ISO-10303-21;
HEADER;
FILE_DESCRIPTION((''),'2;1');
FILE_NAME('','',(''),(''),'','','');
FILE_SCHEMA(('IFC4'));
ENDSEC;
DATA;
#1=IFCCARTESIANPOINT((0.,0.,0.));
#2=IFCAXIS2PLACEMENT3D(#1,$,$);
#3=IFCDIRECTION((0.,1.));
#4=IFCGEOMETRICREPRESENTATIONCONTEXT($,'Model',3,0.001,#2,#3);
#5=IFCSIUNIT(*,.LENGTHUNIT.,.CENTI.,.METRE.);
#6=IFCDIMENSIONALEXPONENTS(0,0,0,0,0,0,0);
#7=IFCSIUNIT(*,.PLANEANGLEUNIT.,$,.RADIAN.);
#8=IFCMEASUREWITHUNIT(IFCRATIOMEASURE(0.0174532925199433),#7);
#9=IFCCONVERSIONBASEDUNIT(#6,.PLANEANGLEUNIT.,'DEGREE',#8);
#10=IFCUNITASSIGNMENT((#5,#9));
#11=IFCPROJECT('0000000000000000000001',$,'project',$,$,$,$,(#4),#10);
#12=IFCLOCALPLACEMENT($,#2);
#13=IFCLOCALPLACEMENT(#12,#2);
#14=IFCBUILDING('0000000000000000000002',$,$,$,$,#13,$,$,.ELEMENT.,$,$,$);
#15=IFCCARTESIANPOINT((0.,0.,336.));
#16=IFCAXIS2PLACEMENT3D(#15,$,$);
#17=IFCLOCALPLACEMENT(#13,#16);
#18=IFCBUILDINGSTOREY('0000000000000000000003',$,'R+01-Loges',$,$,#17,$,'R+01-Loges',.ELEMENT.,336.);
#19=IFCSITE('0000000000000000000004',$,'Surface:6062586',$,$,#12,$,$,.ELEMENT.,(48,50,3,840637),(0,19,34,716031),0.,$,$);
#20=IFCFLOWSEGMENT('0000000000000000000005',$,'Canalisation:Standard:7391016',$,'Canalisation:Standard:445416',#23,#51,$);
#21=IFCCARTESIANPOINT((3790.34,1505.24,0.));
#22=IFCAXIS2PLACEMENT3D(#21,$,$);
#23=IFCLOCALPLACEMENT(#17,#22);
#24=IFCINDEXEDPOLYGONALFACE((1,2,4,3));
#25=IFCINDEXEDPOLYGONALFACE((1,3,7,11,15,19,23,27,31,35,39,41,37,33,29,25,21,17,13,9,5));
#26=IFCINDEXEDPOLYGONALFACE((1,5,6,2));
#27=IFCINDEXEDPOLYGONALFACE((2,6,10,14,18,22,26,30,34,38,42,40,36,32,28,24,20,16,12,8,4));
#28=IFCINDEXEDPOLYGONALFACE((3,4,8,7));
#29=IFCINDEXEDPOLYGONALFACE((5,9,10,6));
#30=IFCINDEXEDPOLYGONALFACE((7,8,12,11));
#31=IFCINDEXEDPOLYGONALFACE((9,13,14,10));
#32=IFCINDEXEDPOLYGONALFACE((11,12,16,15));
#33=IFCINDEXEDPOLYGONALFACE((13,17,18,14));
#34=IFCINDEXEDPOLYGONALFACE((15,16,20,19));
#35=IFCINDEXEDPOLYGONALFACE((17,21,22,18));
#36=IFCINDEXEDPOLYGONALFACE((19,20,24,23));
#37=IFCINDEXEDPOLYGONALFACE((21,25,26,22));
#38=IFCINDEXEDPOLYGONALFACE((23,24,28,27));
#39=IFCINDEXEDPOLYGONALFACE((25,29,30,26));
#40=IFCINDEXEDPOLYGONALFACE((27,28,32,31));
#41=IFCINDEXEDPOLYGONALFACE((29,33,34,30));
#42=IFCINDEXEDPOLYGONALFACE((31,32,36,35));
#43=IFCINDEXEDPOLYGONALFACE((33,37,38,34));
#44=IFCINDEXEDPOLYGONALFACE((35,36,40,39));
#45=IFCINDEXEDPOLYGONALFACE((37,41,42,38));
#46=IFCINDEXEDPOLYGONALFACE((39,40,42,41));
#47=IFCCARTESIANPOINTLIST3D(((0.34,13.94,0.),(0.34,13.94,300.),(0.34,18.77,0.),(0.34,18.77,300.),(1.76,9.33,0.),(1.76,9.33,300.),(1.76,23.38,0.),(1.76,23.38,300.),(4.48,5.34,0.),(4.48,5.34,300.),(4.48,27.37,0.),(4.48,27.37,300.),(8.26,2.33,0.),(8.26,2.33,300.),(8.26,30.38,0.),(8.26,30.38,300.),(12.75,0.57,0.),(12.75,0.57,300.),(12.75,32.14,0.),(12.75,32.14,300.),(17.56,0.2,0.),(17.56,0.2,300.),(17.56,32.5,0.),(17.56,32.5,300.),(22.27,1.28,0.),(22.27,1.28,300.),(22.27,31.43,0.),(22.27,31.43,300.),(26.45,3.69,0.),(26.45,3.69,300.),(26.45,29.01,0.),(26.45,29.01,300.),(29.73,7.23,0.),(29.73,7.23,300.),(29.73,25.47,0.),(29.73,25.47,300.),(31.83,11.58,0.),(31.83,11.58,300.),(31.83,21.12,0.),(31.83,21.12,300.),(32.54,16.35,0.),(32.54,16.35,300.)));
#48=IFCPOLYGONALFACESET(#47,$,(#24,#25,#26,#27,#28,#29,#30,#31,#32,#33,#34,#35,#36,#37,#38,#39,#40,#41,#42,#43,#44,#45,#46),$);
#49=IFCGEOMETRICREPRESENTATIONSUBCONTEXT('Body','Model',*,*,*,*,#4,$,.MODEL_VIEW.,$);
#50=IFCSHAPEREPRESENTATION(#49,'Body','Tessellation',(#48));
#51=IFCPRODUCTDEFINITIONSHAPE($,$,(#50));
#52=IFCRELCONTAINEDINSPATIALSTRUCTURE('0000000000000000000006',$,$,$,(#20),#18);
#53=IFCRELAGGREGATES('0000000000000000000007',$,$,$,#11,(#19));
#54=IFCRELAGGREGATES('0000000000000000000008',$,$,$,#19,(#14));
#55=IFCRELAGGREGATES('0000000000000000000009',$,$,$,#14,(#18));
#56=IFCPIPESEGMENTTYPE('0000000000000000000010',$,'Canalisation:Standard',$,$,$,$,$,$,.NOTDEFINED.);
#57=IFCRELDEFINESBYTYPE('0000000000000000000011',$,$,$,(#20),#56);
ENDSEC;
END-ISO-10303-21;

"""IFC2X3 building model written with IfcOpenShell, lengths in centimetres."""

from ifc_helpers import new_model, entity, si_unit, converted_unit, direction, frame, origin, origin_2d_with_axis, place, context, subcontext, project, spatial, circle, extrude, type_object, element, save


model = new_model("IFC2X3")

# Units and contexts
model_context = context("Model", 3, precision=0.001, world=origin(), true_north=direction((0.0, 1.0)))
body_context = subcontext(model_context, "Body", "Model", "MODEL_VIEW")
ifc_project = project(units=[si_unit("LENGTHUNIT", "METRE", prefix="CENTI"), converted_unit("PLANEANGLEUNIT", "DEGREE", entity("IfcRatioMeasure", 0.0174532925199433), si_unit("PLANEANGLEUNIT", "RADIAN"), dimensions=[0, 0, 0, 0, 0, 0, 0])], contexts=[model_context])

# Site, building, storey
site_placement = place(None, origin())
site = spatial("IfcSite", under=ifc_project, at=site_placement, Name="Surface:6062586", CompositionType="ELEMENT", RefLatitude=(48, 50, 3, 840637), RefLongitude=(0, 19, 34, 716031), RefElevation=0.0)
building_placement = place(site_placement, origin())
building = spatial("IfcBuilding", under=site, at=building_placement, CompositionType="ELEMENT")
storey_placement = place(building_placement, frame((0.0, 0.0, 336.0)))
storey = spatial("IfcBuildingStorey", under=building, at=storey_placement, Name="R+01-Loges", LongName="R+01-Loges", CompositionType="ELEMENT", Elevation=336.0)

# Flow segment
pipe_segment_type = type_object("IfcPipeSegmentType", Name="Canalisation:Standard", PredefinedType="NOTDEFINED")
flow_segment_placement = place(storey_placement, frame((3790.34, 1505.24, 0.0)))
element("IfcFlowSegment", 1, at=flow_segment_placement, inside=storey, type_object=pipe_segment_type, Name="Canalisation:Standard:7391016", ObjectType="Canalisation:Standard:445416", context=body_context, shape_type="SweptSolid", body=[
    extrude(circle(Radius=16.19, at=origin_2d_with_axis()), frame((16.35, 16.35, 0.0)), (0.0, 0.0, 1.0), 300.0),
])

save(model, "model.ifc")
